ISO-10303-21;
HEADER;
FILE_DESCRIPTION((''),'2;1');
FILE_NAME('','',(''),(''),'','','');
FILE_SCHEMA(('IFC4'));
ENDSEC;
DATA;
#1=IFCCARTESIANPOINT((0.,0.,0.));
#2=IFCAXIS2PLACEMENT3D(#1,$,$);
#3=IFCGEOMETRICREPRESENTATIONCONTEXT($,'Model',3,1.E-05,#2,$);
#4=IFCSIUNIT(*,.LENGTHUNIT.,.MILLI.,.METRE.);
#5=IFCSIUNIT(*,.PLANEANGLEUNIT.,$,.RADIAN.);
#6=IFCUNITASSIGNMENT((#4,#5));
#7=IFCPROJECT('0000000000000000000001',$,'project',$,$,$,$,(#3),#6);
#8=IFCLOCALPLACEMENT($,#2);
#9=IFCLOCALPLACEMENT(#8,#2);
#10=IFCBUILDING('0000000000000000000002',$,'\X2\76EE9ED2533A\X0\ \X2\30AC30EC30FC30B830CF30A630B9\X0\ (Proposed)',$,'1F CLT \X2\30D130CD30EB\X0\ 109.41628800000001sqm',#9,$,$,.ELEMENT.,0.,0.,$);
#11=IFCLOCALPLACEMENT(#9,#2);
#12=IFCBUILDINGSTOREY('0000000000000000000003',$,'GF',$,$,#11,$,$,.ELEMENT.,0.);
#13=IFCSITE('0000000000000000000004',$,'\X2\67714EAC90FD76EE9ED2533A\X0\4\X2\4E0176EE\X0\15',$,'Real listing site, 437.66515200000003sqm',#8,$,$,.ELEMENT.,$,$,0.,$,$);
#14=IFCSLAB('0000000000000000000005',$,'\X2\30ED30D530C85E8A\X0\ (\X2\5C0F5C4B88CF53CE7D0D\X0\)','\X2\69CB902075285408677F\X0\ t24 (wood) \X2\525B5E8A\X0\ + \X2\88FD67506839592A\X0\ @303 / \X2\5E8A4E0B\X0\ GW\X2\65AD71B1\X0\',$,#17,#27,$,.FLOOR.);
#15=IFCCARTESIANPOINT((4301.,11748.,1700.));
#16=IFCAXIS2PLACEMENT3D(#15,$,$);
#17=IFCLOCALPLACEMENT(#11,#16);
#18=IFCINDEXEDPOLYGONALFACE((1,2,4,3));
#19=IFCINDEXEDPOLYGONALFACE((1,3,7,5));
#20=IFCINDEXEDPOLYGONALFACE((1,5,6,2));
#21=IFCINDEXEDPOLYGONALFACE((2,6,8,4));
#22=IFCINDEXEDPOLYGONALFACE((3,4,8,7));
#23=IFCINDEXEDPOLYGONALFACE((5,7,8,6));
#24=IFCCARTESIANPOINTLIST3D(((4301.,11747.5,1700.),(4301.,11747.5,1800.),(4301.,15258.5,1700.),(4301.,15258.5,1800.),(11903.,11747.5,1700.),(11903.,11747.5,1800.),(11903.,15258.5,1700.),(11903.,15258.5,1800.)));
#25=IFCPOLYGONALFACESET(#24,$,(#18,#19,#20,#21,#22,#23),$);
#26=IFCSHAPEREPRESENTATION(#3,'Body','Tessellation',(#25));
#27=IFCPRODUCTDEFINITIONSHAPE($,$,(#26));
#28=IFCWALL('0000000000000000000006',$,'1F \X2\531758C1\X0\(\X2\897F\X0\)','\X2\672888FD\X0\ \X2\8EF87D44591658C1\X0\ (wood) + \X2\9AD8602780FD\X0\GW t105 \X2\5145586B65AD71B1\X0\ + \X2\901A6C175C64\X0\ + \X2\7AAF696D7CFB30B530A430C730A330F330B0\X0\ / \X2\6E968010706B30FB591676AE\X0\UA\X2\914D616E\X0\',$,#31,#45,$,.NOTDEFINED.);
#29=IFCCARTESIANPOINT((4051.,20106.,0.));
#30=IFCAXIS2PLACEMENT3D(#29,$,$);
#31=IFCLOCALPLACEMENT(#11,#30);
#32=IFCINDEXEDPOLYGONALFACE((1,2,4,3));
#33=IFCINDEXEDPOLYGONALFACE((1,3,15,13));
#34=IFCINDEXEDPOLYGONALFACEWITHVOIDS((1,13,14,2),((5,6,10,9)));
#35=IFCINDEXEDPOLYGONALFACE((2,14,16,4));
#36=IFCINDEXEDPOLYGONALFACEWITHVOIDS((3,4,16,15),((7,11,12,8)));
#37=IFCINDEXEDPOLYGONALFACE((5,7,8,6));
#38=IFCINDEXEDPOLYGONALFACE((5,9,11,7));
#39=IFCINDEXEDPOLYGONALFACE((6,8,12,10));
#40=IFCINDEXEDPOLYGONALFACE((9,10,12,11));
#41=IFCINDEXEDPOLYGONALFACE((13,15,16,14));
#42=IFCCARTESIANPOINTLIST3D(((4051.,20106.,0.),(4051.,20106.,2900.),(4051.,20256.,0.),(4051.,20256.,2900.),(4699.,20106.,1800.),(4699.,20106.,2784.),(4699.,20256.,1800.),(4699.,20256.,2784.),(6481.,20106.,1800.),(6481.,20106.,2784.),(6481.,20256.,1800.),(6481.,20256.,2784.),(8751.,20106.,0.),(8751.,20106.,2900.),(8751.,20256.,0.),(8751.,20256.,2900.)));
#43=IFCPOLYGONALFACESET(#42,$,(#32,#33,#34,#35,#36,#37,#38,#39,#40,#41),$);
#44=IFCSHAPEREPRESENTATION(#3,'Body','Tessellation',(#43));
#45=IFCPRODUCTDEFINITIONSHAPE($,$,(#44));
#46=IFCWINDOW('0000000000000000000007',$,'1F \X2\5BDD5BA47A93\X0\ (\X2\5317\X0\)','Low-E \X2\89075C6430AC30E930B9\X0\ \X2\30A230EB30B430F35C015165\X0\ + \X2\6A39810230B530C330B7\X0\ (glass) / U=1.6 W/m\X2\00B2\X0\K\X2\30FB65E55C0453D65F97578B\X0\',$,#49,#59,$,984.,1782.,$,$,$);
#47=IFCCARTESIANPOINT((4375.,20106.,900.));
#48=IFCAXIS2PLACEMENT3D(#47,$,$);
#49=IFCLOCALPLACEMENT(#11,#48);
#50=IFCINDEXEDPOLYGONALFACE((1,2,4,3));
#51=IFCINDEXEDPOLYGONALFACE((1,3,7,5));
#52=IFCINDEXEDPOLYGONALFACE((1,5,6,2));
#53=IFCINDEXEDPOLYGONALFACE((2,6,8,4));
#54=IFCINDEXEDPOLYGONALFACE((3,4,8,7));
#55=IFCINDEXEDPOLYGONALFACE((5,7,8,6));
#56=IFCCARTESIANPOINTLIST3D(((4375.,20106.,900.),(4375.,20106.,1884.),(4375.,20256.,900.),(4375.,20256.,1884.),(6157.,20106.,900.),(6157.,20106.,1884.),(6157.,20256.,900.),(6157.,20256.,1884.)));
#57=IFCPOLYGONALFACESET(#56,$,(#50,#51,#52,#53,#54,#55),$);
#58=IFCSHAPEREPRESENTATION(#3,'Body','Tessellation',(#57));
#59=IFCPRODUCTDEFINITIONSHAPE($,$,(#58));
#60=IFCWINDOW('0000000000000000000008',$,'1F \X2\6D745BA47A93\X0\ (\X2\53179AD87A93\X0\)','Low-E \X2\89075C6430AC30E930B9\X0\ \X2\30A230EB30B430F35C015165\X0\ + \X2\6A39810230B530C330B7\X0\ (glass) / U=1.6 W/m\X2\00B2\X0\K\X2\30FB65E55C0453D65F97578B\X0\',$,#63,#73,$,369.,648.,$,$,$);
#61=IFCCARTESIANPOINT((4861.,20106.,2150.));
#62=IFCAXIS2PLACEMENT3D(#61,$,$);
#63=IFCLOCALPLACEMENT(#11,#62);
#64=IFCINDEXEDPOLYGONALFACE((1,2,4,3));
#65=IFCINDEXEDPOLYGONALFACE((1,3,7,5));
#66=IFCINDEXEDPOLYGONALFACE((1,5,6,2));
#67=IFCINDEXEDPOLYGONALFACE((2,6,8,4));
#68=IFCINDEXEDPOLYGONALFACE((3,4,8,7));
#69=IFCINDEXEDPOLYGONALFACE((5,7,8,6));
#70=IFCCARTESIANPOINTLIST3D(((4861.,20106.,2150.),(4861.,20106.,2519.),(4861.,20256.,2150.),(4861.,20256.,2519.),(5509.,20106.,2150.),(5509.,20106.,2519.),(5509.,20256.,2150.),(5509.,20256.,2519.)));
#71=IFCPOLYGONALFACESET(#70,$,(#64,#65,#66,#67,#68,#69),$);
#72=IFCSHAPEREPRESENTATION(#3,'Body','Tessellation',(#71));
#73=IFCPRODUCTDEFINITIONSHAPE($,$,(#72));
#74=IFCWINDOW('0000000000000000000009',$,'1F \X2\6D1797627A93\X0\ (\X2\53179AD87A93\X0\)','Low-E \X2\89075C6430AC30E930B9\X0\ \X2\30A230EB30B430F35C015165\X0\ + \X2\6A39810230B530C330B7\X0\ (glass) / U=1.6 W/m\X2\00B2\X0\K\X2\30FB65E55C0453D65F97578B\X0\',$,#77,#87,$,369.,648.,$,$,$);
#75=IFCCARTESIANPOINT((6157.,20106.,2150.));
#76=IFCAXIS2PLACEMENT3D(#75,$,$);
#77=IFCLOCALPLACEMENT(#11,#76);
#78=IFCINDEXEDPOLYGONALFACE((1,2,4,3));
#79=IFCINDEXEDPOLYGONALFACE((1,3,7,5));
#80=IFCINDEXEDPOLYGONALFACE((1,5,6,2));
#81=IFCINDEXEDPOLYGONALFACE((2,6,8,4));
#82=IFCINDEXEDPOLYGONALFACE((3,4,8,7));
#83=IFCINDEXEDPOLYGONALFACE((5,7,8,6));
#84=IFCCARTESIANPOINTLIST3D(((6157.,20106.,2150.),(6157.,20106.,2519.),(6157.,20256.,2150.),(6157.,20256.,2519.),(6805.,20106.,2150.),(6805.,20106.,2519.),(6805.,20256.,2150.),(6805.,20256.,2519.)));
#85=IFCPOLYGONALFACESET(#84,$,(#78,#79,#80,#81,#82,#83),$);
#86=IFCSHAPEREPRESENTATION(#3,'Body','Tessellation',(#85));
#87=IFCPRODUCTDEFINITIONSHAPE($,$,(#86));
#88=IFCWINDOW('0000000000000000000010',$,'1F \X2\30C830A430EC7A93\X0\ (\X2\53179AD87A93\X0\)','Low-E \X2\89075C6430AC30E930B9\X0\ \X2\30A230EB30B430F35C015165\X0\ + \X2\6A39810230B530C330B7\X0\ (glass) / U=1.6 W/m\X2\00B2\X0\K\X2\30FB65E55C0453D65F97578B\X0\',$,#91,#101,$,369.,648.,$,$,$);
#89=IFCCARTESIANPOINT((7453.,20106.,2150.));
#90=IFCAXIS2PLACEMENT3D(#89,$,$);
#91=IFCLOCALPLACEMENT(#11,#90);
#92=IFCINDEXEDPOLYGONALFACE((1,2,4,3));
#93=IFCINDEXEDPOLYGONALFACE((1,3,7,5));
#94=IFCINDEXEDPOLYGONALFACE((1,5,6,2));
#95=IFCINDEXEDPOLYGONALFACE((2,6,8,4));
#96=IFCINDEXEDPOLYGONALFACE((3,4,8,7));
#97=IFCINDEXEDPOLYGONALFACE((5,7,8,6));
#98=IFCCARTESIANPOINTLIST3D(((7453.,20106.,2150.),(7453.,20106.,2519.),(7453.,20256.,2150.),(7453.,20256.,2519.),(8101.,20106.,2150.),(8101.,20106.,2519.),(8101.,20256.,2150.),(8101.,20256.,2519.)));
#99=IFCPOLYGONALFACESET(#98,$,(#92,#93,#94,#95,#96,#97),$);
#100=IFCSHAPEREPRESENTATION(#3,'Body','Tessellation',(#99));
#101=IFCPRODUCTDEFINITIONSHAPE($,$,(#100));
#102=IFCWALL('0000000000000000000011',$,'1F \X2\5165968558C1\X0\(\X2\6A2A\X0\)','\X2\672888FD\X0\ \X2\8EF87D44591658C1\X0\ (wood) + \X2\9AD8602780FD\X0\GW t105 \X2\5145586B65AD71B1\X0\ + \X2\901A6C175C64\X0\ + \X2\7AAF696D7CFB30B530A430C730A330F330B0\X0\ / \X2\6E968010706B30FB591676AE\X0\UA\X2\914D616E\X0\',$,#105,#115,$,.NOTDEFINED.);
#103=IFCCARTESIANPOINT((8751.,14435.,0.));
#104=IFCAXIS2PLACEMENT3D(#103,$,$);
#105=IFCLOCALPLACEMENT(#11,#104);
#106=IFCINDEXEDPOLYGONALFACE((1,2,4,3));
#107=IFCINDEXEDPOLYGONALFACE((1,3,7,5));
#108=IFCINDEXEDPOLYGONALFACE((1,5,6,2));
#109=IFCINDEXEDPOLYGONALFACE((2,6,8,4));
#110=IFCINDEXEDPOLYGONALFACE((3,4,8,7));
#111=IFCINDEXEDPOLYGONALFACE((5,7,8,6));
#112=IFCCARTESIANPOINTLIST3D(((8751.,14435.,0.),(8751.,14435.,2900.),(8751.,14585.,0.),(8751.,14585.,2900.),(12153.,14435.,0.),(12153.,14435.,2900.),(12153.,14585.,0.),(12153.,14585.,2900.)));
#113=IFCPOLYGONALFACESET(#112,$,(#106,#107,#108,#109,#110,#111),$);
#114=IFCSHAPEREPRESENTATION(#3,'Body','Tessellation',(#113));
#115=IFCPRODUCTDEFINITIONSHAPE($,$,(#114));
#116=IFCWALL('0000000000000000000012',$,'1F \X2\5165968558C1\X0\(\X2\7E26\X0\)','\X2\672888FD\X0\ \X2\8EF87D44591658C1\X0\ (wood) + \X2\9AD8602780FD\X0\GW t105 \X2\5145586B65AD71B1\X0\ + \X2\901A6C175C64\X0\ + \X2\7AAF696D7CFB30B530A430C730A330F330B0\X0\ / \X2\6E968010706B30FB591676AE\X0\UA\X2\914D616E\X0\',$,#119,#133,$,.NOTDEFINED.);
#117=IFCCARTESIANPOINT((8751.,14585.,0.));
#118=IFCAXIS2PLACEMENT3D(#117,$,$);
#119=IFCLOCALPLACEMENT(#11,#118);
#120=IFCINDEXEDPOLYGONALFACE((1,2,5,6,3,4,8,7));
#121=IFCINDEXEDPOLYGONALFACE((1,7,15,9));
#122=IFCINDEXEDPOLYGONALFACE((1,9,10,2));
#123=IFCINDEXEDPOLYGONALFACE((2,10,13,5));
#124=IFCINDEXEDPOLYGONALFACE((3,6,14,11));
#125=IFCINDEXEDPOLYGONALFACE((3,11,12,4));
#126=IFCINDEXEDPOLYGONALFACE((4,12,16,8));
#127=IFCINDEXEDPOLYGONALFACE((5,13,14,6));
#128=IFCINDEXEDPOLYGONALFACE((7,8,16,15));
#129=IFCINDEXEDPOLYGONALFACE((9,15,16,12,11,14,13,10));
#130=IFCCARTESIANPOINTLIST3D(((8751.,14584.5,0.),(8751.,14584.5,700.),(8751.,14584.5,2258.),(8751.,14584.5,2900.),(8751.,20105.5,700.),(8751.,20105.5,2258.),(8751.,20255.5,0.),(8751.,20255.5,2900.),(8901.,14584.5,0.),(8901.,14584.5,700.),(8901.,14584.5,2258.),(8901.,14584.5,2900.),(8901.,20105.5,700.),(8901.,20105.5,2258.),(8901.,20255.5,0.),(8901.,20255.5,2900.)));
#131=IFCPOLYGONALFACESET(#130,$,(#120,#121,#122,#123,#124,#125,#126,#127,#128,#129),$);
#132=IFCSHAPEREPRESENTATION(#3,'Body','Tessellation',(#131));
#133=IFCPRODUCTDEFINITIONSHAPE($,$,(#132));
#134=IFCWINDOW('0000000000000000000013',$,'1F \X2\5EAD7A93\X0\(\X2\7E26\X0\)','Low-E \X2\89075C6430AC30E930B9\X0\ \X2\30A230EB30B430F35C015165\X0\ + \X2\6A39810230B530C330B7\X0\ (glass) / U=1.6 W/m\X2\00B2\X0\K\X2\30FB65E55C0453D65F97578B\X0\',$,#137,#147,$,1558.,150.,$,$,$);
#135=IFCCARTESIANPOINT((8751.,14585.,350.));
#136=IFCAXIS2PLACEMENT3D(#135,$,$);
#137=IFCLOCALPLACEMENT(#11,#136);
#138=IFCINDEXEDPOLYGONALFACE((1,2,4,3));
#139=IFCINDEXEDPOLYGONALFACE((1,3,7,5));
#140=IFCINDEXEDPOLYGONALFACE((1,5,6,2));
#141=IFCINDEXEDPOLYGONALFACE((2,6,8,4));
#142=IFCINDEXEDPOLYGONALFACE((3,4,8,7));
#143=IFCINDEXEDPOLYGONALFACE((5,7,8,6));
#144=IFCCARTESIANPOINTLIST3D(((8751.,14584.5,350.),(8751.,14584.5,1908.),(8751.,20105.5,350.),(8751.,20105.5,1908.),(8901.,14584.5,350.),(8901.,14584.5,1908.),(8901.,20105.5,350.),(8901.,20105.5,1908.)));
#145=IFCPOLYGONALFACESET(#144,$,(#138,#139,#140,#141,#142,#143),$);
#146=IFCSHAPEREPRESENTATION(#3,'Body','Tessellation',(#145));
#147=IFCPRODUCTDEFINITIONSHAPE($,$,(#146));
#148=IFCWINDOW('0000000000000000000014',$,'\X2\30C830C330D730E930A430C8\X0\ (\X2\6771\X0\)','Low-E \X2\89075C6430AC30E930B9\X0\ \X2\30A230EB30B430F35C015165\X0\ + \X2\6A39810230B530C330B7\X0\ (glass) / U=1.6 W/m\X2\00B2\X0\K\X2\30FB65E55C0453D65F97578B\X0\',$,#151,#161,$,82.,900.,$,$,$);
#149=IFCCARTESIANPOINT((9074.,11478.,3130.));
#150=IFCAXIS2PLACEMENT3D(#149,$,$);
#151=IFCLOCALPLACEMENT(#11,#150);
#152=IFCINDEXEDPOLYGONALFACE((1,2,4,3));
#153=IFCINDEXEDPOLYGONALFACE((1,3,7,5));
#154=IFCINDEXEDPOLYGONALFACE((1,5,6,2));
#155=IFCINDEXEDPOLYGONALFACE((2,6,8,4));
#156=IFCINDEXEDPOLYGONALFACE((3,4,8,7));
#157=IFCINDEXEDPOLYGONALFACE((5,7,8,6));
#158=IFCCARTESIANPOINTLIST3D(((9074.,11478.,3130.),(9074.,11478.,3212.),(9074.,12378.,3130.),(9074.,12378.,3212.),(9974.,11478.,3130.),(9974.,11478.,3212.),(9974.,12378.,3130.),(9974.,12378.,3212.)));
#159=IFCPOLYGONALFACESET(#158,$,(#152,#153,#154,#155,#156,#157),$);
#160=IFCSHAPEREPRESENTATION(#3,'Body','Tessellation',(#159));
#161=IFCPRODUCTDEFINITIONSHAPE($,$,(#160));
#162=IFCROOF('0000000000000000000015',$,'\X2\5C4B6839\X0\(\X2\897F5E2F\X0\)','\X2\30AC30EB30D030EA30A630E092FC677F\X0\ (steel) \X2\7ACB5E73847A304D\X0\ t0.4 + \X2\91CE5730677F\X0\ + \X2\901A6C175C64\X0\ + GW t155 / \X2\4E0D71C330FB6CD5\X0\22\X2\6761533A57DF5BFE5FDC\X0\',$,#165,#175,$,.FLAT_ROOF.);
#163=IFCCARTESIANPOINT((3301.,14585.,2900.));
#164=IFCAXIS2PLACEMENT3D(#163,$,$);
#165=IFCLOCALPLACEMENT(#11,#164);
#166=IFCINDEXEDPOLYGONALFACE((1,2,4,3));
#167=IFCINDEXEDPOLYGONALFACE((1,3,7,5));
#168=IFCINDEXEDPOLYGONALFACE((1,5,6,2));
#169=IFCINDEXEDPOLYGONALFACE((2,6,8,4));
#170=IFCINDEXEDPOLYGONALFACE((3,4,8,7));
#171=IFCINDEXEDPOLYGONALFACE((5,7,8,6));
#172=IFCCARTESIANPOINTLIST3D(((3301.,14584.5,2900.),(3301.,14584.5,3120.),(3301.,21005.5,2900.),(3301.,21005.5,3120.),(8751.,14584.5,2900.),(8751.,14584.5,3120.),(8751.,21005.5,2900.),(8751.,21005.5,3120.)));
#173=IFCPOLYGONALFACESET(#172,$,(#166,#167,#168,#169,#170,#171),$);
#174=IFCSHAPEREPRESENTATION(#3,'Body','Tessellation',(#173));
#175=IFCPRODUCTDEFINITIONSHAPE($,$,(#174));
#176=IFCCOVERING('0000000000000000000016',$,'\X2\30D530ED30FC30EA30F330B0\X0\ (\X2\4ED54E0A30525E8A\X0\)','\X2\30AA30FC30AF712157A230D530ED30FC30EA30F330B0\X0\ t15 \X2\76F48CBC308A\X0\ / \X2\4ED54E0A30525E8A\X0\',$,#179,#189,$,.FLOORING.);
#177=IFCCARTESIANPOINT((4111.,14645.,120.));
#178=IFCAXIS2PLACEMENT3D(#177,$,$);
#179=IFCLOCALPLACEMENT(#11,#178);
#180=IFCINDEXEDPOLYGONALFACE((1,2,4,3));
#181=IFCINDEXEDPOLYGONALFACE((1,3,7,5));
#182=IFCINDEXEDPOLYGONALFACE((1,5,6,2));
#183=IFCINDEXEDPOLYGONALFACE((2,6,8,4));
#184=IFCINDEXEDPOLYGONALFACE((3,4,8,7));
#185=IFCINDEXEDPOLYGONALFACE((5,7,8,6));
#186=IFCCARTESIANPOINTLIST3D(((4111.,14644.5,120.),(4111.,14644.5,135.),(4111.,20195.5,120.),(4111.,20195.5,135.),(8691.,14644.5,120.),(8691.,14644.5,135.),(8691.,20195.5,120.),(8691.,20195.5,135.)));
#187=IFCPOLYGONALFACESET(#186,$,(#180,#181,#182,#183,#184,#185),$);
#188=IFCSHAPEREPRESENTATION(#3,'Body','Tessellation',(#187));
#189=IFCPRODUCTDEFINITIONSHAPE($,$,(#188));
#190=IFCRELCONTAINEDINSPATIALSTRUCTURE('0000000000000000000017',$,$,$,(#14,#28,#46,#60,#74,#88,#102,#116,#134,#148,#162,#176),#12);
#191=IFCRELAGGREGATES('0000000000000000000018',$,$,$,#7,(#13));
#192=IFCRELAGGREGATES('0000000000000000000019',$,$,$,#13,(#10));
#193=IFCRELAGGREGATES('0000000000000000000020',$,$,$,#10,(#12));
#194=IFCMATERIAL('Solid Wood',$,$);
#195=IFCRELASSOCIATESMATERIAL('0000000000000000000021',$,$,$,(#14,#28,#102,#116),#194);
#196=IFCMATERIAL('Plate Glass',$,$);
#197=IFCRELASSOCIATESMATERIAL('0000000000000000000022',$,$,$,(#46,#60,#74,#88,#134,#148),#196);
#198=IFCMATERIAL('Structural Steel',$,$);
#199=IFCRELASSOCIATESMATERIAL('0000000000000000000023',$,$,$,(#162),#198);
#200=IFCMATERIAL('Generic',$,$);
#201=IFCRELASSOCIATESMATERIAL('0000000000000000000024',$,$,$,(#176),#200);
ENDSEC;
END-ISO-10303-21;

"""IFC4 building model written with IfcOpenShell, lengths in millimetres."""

from ifc_helpers import new_model, si_unit, frame, frame_2d, origin, place, context, project, spatial, rectangle, extrude, material, element, fill, save


model = new_model("IFC4")

# Units and contexts
model_context = context("Model", 3, precision=1e-05, world=origin())
ifc_project = project(units=[si_unit("LENGTHUNIT", "METRE", prefix="MILLI"), si_unit("PLANEANGLEUNIT", "RADIAN")], contexts=[model_context])

# Site, building, storey
site_placement = place(None, origin())
site = spatial("IfcSite", under=ifc_project, at=site_placement, Name="東京都目黒区4丁目15", ObjectType="Real listing site, 437.66515200000003sqm", CompositionType="ELEMENT", RefElevation=0.0)
building_placement = place(site_placement, origin())
building = spatial("IfcBuilding", under=site, at=building_placement, Name="目黒区 ガレージハウス (Proposed)", ObjectType="1F CLT パネル 109.41628800000001sqm", CompositionType="ELEMENT", ElevationOfRefHeight=0.0, ElevationOfTerrain=0.0)
storey_placement = place(building_placement, origin())
storey = spatial("IfcBuildingStorey", under=building, at=storey_placement, Name="GF", CompositionType="ELEMENT", Elevation=0.0)

# Slab
ifc_material_1 = material(Name="Solid Wood")
slab_1_placement = place(storey_placement, frame((4301.0, 11748.0, 1700.0)))
element("IfcSlab", 1, at=slab_1_placement, inside=storey, material=ifc_material_1, Name="ロフト床 (小屋裏収納)", Description="構造用合板 t24 (wood) 剛床 + 製材根太 @303 / 床下 GW断熱", PredefinedType="FLOOR", context=model_context, shape_type="SweptSolid", body=[
    extrude(rectangle(XDim=7602.0, YDim=3511.0, at=frame_2d((3801.0, 1755.0))), frame((4301.0, 11748.0, 1700.0)), (0.0, 0.0, 1.0), 100.0),
])

# Wall, openings, windows
wall_1_placement = place(storey_placement, frame((4051.0, 20106.0, 0.0)))
wall_1 = element("IfcWall", 2, at=wall_1_placement, inside=storey, material=ifc_material_1, Name="1F 北壁(西)", Description="木製 軸組外壁 (wood) + 高性能GW t105 充填断熱 + 通気層 + 窯業系サイディング / 準耐火・外皮UA配慮", PredefinedType="NOTDEFINED", context=model_context, shape_type="SweptSolid", body=[
    extrude(rectangle(XDim=4700.0, YDim=150.0, at=frame_2d((2350.0, 75.0))), frame((4051.0, 20106.0, 0.0)), (0.0, 0.0, 1.0), 2900.0),
])
opening_1_placement = place(storey_placement, frame((4375.0, 20106.0, 900.0)))
opening_1 = element("IfcOpeningElement", 3, at=opening_1_placement, cuts=wall_1, PredefinedType="NOTDEFINED", context=model_context, shape_type="SweptSolid", body=[
    extrude(rectangle(XDim=1782.0, YDim=150.0, at=frame_2d((891.0, 75.0))), frame((4375.0, 20106.0, 900.0)), (0.0, 0.0, 1.0), 984.0),
])
opening_2_placement = place(storey_placement, frame((4861.0, 20106.0, 2150.0)))
opening_2 = element("IfcOpeningElement", 4, at=opening_2_placement, cuts=wall_1, PredefinedType="NOTDEFINED", context=model_context, shape_type="SweptSolid", body=[
    extrude(rectangle(XDim=648.0, YDim=150.0, at=frame_2d((324.0, 75.0))), frame((4861.0, 20106.0, 2150.0)), (0.0, 0.0, 1.0), 369.0),
])
opening_3_placement = place(storey_placement, frame((6157.0, 20106.0, 2150.0)))
opening_3 = element("IfcOpeningElement", 5, at=opening_3_placement, cuts=wall_1, PredefinedType="NOTDEFINED", context=model_context, shape_type="SweptSolid", body=[
    extrude(rectangle(XDim=648.0, YDim=150.0, at=frame_2d((324.0, 75.0))), frame((6157.0, 20106.0, 2150.0)), (0.0, 0.0, 1.0), 369.0),
])
opening_4_placement = place(storey_placement, frame((7453.0, 20106.0, 2150.0)))
opening_4 = element("IfcOpeningElement", 6, at=opening_4_placement, cuts=wall_1, PredefinedType="NOTDEFINED", context=model_context, shape_type="SweptSolid", body=[
    extrude(rectangle(XDim=648.0, YDim=150.0, at=frame_2d((324.0, 75.0))), frame((7453.0, 20106.0, 2150.0)), (0.0, 0.0, 1.0), 369.0),
])
ifc_material_2 = material(Name="Plate Glass")
window_1_placement = place(storey_placement, frame((4375.0, 20106.0, 900.0)))
window_1 = element("IfcWindow", 7, at=window_1_placement, inside=storey, material=ifc_material_2, Name="1F 寝室窓 (北)", Description="Low-E 複層ガラス アルゴン封入 + 樹脂サッシ (glass) / U=1.6 W/m²K・日射取得型", OverallHeight=984.0, OverallWidth=1782.0, context=model_context, shape_type="SweptSolid", body=[
    extrude(rectangle(XDim=1782.0, YDim=150.0, at=frame_2d((891.0, 75.0))), frame((4375.0, 20106.0, 900.0)), (0.0, 0.0, 1.0), 984.0),
])
fill(opening_1, window_1)
window_2_placement = place(storey_placement, frame((4861.0, 20106.0, 2150.0)))
window_2 = element("IfcWindow", 8, at=window_2_placement, inside=storey, material=ifc_material_2, Name="1F 浴室窓 (北高窓)", Description="Low-E 複層ガラス アルゴン封入 + 樹脂サッシ (glass) / U=1.6 W/m²K・日射取得型", OverallHeight=369.0, OverallWidth=648.0, context=model_context, shape_type="SweptSolid", body=[
    extrude(rectangle(XDim=648.0, YDim=150.0, at=frame_2d((324.0, 75.0))), frame((4861.0, 20106.0, 2150.0)), (0.0, 0.0, 1.0), 369.0),
])
fill(opening_2, window_2)
window_3_placement = place(storey_placement, frame((6157.0, 20106.0, 2150.0)))
window_3 = element("IfcWindow", 9, at=window_3_placement, inside=storey, material=ifc_material_2, Name="1F 洗面窓 (北高窓)", Description="Low-E 複層ガラス アルゴン封入 + 樹脂サッシ (glass) / U=1.6 W/m²K・日射取得型", OverallHeight=369.0, OverallWidth=648.0, context=model_context, shape_type="SweptSolid", body=[
    extrude(rectangle(XDim=648.0, YDim=150.0, at=frame_2d((324.0, 75.0))), frame((6157.0, 20106.0, 2150.0)), (0.0, 0.0, 1.0), 369.0),
])
fill(opening_3, window_3)
window_4_placement = place(storey_placement, frame((7453.0, 20106.0, 2150.0)))
window_4 = element("IfcWindow", 10, at=window_4_placement, inside=storey, material=ifc_material_2, Name="1F トイレ窓 (北高窓)", Description="Low-E 複層ガラス アルゴン封入 + 樹脂サッシ (glass) / U=1.6 W/m²K・日射取得型", OverallHeight=369.0, OverallWidth=648.0, context=model_context, shape_type="SweptSolid", body=[
    extrude(rectangle(XDim=648.0, YDim=150.0, at=frame_2d((324.0, 75.0))), frame((7453.0, 20106.0, 2150.0)), (0.0, 0.0, 1.0), 369.0),
])
fill(opening_4, window_4)

# Wall
wall_2_placement = place(storey_placement, frame((8751.0, 14435.0, 0.0)))
element("IfcWall", 11, at=wall_2_placement, inside=storey, material=ifc_material_1, Name="1F 入隅壁(横)", Description="木製 軸組外壁 (wood) + 高性能GW t105 充填断熱 + 通気層 + 窯業系サイディング / 準耐火・外皮UA配慮", PredefinedType="NOTDEFINED", context=model_context, shape_type="SweptSolid", body=[
    extrude(rectangle(XDim=3402.0, YDim=150.0, at=frame_2d((1701.0, 75.0))), frame((8751.0, 14435.0, 0.0)), (0.0, 0.0, 1.0), 2900.0),
])

# Wall, opening, window
wall_3_placement = place(storey_placement, frame((8751.0, 14585.0, 0.0)))
wall_3 = element("IfcWall", 12, at=wall_3_placement, inside=storey, material=ifc_material_1, Name="1F 入隅壁(縦)", Description="木製 軸組外壁 (wood) + 高性能GW t105 充填断熱 + 通気層 + 窯業系サイディング / 準耐火・外皮UA配慮", PredefinedType="NOTDEFINED", context=model_context, shape_type="SweptSolid", body=[
    extrude(rectangle(XDim=150.0, YDim=5671.0, at=frame_2d((75.0, 2835.0))), frame((8751.0, 14585.0, 0.0)), (0.0, 0.0, 1.0), 2900.0),
])
opening_5_placement = place(storey_placement, frame((8751.0, 14585.0, 350.0)))
opening_5 = element("IfcOpeningElement", 13, at=opening_5_placement, cuts=wall_3, PredefinedType="NOTDEFINED", context=model_context, shape_type="SweptSolid", body=[
    extrude(rectangle(XDim=150.0, YDim=5521.0, at=frame_2d((75.0, 2760.0))), frame((8751.0, 14585.0, 350.0)), (0.0, 0.0, 1.0), 1558.0),
])
window_5_placement = place(storey_placement, frame((8751.0, 14585.0, 350.0)))
window_5 = element("IfcWindow", 14, at=window_5_placement, inside=storey, material=ifc_material_2, Name="1F 庭窓(縦)", Description="Low-E 複層ガラス アルゴン封入 + 樹脂サッシ (glass) / U=1.6 W/m²K・日射取得型", OverallHeight=1558.0, OverallWidth=150.0, context=model_context, shape_type="SweptSolid", body=[
    extrude(rectangle(XDim=150.0, YDim=5521.0, at=frame_2d((75.0, 2760.0))), frame((8751.0, 14585.0, 350.0)), (0.0, 0.0, 1.0), 1558.0),
])
fill(opening_5, window_5)

# Window
window_6_placement = place(storey_placement, frame((9074.0, 11478.0, 3130.0)))
element("IfcWindow", 15, at=window_6_placement, inside=storey, material=ifc_material_2, Name="トップライト (東)", Description="Low-E 複層ガラス アルゴン封入 + 樹脂サッシ (glass) / U=1.6 W/m²K・日射取得型", OverallHeight=82.0, OverallWidth=900.0, context=model_context, shape_type="SweptSolid", body=[
    extrude(rectangle(XDim=900.0, YDim=900.0, at=frame_2d((450.0, 450.0))), frame((9074.0, 11478.0, 3130.0)), (0.0, 0.0, 1.0), 82.0),
])

# Roof
ifc_material_3 = material(Name="Structural Steel")
roof_placement = place(storey_placement, frame((3301.0, 14585.0, 2900.0)))
element("IfcRoof", 16, at=roof_placement, inside=storey, material=ifc_material_3, Name="屋根(西帯)", Description="ガルバリウム鋼板 (steel) 立平葺き t0.4 + 野地板 + 通気層 + GW t155 / 不燃・法22条区域対応", PredefinedType="FLAT_ROOF", context=model_context, shape_type="SweptSolid", body=[
    extrude(rectangle(XDim=5450.0, YDim=6421.0, at=frame_2d((2725.0, 3210.0))), frame((3301.0, 14585.0, 2900.0)), (0.0, 0.0, 1.0), 220.0),
])

# Covering
ifc_material_4 = material(Name="Generic")
covering_placement = place(storey_placement, frame((4111.0, 14645.0, 120.0)))
element("IfcCovering", 17, at=covering_placement, inside=storey, material=ifc_material_4, Name="フローリング (仕上げ床)", Description="オーク無垢フローリング t15 直貼り / 仕上げ床", PredefinedType="FLOORING", context=model_context, shape_type="SweptSolid", body=[
    extrude(rectangle(XDim=4580.0, YDim=5551.0, at=frame_2d((2290.0, 2775.0))), frame((4111.0, 14645.0, 120.0)), (0.0, 0.0, 1.0), 15.0),
])

save(model, "model.ifc")
